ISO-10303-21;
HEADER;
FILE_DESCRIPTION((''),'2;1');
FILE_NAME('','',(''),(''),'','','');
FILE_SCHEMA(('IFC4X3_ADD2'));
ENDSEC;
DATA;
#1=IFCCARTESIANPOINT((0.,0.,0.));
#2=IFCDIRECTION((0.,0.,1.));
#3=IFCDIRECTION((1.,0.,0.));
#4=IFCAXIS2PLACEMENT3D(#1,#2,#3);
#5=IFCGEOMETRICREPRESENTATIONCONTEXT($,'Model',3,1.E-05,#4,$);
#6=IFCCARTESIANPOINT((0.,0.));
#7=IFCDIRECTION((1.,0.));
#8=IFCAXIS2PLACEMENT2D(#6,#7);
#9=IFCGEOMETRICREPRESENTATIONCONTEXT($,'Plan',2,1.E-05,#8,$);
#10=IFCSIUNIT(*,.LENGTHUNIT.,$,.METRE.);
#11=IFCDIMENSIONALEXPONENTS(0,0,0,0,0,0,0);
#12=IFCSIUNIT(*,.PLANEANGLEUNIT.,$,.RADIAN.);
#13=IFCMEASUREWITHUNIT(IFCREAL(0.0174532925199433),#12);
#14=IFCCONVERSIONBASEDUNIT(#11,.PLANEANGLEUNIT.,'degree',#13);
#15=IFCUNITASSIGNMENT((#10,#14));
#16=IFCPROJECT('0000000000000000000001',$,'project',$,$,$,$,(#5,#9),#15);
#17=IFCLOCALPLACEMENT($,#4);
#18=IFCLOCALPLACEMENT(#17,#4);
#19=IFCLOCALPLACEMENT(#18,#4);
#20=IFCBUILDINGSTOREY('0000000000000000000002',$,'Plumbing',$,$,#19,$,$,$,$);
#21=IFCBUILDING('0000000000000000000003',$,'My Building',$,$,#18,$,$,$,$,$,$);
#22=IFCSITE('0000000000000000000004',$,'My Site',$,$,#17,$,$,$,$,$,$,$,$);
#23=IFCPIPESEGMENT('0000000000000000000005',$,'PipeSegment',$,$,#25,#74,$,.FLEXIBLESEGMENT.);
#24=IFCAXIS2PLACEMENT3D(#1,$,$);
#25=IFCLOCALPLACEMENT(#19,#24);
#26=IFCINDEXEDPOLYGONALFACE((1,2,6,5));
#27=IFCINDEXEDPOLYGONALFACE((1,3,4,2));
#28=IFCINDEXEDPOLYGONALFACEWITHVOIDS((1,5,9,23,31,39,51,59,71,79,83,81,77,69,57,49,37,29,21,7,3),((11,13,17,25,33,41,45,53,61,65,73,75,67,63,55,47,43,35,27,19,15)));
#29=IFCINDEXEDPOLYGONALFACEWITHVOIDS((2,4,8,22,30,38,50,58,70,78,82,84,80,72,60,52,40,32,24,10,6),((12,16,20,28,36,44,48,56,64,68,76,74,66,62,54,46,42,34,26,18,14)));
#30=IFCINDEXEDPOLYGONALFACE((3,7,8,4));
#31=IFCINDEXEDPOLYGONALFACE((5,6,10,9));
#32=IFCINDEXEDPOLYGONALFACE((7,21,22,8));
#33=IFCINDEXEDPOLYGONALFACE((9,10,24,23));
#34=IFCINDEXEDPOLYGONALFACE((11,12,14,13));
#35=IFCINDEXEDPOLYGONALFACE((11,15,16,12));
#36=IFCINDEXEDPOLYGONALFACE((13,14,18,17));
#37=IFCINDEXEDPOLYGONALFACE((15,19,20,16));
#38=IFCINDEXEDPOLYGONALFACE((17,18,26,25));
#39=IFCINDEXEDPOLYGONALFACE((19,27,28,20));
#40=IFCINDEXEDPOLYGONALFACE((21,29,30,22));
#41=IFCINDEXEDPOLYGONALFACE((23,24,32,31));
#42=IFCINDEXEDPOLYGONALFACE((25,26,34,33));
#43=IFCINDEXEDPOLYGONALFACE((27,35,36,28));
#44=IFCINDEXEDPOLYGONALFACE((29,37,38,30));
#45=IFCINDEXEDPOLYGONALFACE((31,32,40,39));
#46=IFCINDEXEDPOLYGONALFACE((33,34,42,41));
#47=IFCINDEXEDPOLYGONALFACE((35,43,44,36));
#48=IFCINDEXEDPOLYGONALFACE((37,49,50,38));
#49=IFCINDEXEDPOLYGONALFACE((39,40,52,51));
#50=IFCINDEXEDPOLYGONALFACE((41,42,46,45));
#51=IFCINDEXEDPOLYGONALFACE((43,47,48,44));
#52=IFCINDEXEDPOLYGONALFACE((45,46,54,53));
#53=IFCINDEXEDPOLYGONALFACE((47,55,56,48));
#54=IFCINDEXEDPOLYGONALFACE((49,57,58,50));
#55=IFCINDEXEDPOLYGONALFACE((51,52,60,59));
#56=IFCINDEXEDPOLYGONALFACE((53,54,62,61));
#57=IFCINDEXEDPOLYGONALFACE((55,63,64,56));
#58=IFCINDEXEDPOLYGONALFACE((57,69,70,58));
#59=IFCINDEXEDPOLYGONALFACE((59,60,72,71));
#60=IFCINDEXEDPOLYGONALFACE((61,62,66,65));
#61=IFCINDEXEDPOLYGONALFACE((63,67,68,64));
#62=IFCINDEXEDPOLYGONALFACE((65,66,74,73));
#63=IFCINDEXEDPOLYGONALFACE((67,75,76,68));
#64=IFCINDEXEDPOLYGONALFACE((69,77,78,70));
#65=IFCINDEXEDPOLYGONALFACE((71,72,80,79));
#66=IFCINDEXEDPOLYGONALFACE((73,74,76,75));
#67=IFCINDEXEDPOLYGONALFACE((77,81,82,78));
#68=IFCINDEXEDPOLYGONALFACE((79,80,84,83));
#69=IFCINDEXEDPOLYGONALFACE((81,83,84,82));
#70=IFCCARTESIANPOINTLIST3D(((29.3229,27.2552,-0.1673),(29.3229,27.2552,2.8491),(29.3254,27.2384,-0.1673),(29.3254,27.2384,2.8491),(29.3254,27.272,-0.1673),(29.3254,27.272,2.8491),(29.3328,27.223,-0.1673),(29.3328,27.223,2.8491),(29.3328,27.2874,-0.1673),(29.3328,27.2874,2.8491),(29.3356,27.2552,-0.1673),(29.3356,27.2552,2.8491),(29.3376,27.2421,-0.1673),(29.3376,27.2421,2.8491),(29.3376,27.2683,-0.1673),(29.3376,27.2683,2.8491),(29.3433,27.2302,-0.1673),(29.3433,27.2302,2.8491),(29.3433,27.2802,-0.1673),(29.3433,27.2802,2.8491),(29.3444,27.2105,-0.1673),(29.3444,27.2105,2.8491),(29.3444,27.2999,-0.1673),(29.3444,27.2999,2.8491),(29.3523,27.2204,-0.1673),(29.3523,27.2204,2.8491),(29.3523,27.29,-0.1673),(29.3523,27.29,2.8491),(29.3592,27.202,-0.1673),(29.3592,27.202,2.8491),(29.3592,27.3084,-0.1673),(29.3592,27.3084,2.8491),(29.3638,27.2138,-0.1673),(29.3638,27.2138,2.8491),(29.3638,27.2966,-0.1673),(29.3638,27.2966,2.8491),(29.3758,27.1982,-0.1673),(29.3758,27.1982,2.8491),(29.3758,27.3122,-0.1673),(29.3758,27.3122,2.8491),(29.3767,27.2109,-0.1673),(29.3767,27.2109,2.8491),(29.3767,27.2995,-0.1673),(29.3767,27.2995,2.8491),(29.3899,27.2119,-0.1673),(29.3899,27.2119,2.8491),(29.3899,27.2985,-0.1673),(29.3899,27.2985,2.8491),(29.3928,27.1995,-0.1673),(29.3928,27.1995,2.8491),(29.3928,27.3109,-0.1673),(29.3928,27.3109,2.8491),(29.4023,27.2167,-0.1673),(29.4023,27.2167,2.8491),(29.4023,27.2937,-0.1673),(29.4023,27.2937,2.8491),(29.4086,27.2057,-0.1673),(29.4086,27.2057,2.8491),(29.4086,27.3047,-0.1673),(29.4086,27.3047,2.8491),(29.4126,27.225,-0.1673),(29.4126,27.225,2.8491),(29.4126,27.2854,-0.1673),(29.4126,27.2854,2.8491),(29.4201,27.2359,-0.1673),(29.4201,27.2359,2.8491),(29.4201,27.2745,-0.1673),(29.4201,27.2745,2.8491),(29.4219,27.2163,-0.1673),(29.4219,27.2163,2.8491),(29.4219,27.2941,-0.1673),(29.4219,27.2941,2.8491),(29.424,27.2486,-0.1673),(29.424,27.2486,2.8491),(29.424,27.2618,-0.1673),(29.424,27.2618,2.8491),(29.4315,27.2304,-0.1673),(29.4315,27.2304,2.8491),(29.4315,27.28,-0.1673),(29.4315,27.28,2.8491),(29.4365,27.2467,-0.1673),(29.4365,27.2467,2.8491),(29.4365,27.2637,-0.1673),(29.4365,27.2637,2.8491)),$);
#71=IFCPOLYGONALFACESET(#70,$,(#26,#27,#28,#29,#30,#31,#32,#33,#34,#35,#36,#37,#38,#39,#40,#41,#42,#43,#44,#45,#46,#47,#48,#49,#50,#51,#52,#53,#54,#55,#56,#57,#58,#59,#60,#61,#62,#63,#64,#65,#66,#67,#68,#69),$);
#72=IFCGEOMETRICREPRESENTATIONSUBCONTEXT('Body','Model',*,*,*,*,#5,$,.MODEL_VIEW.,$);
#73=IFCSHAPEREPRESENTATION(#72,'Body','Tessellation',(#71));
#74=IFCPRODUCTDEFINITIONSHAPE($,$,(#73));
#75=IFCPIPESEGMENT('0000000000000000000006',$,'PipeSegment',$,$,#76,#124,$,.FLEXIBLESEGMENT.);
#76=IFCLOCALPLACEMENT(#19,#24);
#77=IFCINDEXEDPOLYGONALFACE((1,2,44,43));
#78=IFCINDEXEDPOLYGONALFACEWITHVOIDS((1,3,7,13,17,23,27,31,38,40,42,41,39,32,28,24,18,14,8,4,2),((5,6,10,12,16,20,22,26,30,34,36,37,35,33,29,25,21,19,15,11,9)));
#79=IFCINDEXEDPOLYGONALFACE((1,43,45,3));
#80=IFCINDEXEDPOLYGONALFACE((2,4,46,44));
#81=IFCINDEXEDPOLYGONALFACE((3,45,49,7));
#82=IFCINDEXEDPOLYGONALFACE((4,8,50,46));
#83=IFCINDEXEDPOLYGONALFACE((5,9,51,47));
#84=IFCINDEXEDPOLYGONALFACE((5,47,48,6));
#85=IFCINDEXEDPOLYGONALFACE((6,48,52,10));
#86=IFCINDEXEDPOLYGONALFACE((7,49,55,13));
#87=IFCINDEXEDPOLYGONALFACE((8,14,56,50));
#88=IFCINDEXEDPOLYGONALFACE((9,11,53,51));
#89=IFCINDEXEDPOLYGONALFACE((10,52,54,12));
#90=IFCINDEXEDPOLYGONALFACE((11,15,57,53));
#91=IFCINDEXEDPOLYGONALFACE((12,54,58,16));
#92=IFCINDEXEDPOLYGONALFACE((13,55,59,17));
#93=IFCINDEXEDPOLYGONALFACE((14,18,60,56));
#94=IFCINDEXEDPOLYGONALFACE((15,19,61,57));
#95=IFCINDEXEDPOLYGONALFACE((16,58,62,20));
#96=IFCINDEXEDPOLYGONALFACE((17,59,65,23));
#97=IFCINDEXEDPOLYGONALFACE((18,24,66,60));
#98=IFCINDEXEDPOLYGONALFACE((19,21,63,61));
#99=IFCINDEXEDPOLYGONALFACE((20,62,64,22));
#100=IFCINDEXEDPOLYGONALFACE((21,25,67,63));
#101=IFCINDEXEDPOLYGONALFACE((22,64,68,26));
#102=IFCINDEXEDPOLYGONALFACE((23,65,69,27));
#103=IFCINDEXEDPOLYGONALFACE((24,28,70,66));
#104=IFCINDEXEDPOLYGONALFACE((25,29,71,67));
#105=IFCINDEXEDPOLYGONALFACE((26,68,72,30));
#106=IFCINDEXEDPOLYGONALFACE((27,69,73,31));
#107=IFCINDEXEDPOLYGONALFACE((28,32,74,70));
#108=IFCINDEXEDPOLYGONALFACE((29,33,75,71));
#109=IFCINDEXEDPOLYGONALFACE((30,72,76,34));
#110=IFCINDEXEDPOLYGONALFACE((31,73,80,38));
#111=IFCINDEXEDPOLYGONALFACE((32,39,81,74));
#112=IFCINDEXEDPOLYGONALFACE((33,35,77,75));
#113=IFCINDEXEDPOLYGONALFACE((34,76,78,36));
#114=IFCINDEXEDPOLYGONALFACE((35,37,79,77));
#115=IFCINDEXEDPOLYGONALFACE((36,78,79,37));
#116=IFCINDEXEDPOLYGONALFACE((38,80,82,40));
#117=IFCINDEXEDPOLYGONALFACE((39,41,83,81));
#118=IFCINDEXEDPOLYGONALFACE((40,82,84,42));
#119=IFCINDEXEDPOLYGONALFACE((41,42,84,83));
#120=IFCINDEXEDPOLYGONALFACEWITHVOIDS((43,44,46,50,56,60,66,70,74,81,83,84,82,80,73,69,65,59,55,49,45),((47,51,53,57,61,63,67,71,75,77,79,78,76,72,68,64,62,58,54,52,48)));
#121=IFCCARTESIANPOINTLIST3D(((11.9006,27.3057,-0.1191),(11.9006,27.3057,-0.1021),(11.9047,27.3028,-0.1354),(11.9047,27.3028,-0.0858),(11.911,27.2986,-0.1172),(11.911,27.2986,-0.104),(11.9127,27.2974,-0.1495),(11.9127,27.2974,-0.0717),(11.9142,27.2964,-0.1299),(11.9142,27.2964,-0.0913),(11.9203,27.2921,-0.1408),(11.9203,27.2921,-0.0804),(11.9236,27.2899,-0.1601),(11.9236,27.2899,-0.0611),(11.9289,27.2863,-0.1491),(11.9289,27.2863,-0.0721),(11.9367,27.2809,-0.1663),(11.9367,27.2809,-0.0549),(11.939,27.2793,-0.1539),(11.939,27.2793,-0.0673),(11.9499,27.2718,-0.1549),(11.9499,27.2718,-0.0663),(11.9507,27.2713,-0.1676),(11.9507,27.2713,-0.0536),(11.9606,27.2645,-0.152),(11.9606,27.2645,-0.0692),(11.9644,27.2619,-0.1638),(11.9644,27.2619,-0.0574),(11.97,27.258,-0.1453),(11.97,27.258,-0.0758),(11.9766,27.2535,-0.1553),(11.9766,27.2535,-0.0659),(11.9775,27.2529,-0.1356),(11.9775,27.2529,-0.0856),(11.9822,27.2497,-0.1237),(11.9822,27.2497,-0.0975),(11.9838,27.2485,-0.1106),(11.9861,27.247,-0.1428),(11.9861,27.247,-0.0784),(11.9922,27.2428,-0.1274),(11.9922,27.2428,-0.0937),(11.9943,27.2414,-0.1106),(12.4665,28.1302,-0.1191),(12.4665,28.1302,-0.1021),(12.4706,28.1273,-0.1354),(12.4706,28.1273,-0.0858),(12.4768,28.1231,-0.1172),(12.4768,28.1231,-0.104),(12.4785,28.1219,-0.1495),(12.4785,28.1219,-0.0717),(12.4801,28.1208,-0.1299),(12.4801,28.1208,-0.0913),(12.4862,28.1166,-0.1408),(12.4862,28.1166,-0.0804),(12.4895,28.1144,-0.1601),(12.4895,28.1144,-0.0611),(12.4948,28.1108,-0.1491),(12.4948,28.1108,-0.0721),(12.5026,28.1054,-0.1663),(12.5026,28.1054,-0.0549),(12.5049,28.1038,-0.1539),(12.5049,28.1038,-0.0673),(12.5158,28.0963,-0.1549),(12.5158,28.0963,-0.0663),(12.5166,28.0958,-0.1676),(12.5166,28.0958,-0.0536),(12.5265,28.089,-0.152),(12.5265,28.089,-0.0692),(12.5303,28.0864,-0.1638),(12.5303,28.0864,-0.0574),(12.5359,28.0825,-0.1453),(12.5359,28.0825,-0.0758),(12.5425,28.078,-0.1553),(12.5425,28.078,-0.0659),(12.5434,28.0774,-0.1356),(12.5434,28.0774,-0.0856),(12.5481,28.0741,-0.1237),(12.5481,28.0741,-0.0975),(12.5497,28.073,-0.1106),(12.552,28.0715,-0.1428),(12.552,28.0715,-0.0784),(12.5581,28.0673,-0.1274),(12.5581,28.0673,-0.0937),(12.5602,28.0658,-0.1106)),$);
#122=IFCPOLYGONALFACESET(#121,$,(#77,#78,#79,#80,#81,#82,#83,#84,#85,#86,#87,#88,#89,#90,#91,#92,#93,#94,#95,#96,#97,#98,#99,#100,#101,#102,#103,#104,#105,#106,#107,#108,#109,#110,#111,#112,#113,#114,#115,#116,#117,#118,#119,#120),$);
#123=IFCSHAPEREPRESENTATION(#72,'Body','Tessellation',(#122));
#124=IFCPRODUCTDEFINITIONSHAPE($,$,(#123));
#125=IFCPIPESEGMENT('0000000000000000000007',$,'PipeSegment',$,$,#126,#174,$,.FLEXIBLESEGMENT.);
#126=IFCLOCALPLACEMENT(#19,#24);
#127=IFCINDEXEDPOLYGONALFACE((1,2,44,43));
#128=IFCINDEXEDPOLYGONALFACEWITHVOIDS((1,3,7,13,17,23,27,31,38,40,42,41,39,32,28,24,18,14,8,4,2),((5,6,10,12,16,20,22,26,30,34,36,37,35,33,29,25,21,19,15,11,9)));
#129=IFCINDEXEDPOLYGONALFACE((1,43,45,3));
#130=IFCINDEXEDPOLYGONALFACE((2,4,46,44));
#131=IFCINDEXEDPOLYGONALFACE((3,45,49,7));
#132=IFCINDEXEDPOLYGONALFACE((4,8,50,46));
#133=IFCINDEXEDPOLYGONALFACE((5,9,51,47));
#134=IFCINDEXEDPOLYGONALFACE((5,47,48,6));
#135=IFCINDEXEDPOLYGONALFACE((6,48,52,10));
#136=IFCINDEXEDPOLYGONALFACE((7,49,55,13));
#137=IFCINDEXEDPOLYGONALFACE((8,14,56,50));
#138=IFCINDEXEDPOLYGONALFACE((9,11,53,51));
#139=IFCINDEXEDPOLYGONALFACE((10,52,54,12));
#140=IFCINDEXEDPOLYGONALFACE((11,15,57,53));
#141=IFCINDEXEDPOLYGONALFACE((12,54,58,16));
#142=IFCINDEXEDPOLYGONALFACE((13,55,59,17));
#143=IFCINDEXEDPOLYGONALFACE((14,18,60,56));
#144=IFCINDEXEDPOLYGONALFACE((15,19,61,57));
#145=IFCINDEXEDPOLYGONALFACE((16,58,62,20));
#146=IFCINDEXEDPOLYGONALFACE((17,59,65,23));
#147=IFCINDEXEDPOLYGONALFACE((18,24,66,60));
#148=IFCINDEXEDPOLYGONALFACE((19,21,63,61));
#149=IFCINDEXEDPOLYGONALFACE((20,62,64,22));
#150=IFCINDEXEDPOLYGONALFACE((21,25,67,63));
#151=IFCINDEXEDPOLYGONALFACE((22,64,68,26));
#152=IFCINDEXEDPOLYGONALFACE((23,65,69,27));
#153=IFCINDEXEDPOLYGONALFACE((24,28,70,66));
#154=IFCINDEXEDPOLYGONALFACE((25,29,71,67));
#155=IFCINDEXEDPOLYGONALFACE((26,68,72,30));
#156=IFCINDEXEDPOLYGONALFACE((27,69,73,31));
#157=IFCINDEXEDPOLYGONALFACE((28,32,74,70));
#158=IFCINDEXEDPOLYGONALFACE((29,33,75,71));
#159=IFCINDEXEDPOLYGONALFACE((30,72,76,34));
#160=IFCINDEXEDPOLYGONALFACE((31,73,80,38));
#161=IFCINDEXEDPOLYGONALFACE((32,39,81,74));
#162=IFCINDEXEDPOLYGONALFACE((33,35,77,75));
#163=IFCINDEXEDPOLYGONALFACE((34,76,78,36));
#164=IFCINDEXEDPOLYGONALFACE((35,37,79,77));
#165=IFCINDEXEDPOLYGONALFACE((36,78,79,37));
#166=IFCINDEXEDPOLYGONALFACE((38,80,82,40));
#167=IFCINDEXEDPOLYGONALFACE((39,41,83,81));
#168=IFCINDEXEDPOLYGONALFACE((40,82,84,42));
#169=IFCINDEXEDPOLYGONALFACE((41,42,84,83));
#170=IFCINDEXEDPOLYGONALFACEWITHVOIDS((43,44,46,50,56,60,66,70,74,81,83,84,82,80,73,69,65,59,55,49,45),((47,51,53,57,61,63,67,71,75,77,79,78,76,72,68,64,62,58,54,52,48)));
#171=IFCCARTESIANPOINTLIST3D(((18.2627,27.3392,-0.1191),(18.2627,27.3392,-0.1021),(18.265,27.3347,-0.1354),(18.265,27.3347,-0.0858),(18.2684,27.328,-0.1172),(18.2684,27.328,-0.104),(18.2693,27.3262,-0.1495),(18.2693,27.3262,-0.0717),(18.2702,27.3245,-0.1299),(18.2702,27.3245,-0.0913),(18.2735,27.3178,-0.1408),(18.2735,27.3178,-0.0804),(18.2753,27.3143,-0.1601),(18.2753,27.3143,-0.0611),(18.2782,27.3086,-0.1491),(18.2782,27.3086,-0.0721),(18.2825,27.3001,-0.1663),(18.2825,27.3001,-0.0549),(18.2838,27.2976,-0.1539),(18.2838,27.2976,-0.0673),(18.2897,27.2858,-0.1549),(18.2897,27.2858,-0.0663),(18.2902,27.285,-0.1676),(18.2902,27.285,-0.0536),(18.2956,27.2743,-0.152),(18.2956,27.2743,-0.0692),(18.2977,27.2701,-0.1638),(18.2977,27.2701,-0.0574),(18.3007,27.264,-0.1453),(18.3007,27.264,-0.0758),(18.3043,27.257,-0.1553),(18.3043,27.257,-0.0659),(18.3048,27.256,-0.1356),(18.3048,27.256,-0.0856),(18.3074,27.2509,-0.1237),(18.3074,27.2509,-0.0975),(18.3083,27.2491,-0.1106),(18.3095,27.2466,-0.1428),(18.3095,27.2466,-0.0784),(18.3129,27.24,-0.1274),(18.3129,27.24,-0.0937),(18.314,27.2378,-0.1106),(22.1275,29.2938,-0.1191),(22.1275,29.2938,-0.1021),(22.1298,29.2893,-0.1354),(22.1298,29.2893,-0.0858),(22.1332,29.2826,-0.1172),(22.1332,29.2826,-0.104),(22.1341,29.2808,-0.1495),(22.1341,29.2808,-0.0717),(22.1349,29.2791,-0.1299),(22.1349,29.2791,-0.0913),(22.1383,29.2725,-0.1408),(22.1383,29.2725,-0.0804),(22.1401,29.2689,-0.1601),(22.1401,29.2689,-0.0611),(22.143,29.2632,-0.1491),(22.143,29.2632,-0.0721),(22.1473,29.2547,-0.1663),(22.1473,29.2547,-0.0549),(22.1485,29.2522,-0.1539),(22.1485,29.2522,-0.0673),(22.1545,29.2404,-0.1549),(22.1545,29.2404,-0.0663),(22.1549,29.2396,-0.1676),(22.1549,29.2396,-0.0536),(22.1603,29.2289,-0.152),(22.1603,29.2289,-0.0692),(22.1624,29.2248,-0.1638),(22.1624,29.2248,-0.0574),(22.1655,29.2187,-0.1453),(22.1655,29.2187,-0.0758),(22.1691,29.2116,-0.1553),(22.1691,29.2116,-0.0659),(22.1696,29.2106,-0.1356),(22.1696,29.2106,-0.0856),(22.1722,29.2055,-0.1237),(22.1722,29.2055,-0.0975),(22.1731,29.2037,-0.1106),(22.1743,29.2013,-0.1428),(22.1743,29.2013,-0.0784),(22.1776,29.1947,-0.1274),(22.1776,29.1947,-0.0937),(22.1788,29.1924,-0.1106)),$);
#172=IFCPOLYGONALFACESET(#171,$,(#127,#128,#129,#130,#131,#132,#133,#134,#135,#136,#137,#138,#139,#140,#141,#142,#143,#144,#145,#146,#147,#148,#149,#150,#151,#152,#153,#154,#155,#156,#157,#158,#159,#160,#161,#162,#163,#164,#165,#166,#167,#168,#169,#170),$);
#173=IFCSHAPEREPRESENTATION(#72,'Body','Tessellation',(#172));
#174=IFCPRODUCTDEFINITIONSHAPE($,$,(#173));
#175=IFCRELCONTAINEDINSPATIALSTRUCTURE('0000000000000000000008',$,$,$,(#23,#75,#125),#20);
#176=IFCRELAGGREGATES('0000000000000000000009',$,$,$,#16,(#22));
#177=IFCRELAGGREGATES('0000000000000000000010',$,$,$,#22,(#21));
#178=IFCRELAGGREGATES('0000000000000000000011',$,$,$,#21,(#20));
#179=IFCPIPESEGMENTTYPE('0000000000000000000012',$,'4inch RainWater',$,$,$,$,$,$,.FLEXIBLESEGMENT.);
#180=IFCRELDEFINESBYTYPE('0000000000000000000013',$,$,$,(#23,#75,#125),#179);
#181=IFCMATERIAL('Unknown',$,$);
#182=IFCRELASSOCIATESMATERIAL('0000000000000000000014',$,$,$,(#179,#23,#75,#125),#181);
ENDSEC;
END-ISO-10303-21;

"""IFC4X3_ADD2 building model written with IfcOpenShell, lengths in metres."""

from ifc_helpers import new_model, entity, si_unit, converted_unit, frame, origin_with_axes, origin_2d_with_axis, place, context, subcontext, project, spatial, hollow_circle, extrude, material, material_profile, profile_set, profile_usage, type_object, element, save


model = new_model("IFC4X3_ADD2")

# Units and contexts
model_context = context("Model", 3, precision=1e-05, world=origin_with_axes())
plan_context = context("Plan", 2, precision=1e-05, world=origin_2d_with_axis())
body_context = subcontext(model_context, "Body", "Model", "MODEL_VIEW")
ifc_project = project(units=[si_unit("LENGTHUNIT", "METRE"), converted_unit("PLANEANGLEUNIT", "degree", entity("IfcReal", 0.0174532925199433), si_unit("PLANEANGLEUNIT", "RADIAN"), dimensions=[0, 0, 0, 0, 0, 0, 0])], contexts=[model_context, plan_context])

# Site, building, storey
site_placement = place(None, origin_with_axes())
site = spatial("IfcSite", under=ifc_project, at=site_placement, Name="My Site")
building_placement = place(site_placement, origin_with_axes())
building = spatial("IfcBuilding", under=site, at=building_placement, Name="My Building")
storey_placement = place(building_placement, origin_with_axes())
storey = spatial("IfcBuildingStorey", under=building, at=storey_placement, Name="Plumbing")

# Pipe segments
ifc_material_1 = material(Name="Unknown")
ifc_material_profile_1 = material_profile(ifc_material_1, hollow_circle(Radius=0.0571, WallThickness=0.0127))
ifc_profile_set_1 = profile_set([ifc_material_profile_1], Name="rainwater")
ifc_material_profile_2 = material_profile(ifc_material_1, hollow_circle(Radius=0.0571, WallThickness=0.0127))
ifc_profile_set_2 = profile_set([ifc_material_profile_2], Name="rainwater")
pipe_segment_type_1 = type_object("IfcPipeSegmentType", Name="4inch RainWater", PredefinedType="FLEXIBLESEGMENT", material=ifc_profile_set_2)
ifc_profile_usage_1 = profile_usage(ifc_profile_set_1)
pipe_segment_1_placement = place(storey_placement, frame((29.38, 27.2552, -0.1673), z_axis=(0.0, 0.0, 1.0), x_axis=(-1.0, 0.0, 0.0)))
element("IfcPipeSegment", 1, at=pipe_segment_1_placement, inside=storey, type_object=pipe_segment_type_1, material=ifc_profile_usage_1, Name="PipeSegment", PredefinedType="FLEXIBLESEGMENT", context=body_context, shape_type="SweptSolid", body=[
    extrude(hollow_circle(Radius=0.0571, WallThickness=0.0127), origin_with_axes(), (0.0, 0.0, 1.0), 3.0165),
])
ifc_profile_usage_2 = profile_usage(ifc_profile_set_2)
pipe_segment_2_placement = place(storey_placement, frame((11.9472, 27.2737, -0.1106), z_axis=(0.565885, 0.824484, 0.0), x_axis=(0.824484, -0.565885, 0.0)))
element("IfcPipeSegment", 2, at=pipe_segment_2_placement, inside=storey, type_object=pipe_segment_type_1, material=ifc_profile_usage_2, Name="PipeSegment", PredefinedType="FLEXIBLESEGMENT", context=body_context, shape_type="SweptSolid", body=[
    extrude(hollow_circle(Radius=0.0571, WallThickness=0.0127), origin_with_axes(), (0.0, 0.0, 1.0), 1.0),
])
ifc_profile_usage_3 = profile_usage(ifc_profile_set_2)
pipe_segment_3_placement = place(storey_placement, frame((18.2882, 27.2888, -0.1106), z_axis=(0.892364, 0.451317, 0.0), x_axis=(0.451317, -0.892364, 0.0)))
element("IfcPipeSegment", 3, at=pipe_segment_3_placement, inside=storey, type_object=pipe_segment_type_1, material=ifc_profile_usage_3, Name="PipeSegment", PredefinedType="FLEXIBLESEGMENT", context=body_context, shape_type="SweptSolid", body=[
    extrude(hollow_circle(Radius=0.0571, WallThickness=0.0127), origin_with_axes(), (0.0, 0.0, 1.0), 4.3309),
])

save(model, "model.ifc")
